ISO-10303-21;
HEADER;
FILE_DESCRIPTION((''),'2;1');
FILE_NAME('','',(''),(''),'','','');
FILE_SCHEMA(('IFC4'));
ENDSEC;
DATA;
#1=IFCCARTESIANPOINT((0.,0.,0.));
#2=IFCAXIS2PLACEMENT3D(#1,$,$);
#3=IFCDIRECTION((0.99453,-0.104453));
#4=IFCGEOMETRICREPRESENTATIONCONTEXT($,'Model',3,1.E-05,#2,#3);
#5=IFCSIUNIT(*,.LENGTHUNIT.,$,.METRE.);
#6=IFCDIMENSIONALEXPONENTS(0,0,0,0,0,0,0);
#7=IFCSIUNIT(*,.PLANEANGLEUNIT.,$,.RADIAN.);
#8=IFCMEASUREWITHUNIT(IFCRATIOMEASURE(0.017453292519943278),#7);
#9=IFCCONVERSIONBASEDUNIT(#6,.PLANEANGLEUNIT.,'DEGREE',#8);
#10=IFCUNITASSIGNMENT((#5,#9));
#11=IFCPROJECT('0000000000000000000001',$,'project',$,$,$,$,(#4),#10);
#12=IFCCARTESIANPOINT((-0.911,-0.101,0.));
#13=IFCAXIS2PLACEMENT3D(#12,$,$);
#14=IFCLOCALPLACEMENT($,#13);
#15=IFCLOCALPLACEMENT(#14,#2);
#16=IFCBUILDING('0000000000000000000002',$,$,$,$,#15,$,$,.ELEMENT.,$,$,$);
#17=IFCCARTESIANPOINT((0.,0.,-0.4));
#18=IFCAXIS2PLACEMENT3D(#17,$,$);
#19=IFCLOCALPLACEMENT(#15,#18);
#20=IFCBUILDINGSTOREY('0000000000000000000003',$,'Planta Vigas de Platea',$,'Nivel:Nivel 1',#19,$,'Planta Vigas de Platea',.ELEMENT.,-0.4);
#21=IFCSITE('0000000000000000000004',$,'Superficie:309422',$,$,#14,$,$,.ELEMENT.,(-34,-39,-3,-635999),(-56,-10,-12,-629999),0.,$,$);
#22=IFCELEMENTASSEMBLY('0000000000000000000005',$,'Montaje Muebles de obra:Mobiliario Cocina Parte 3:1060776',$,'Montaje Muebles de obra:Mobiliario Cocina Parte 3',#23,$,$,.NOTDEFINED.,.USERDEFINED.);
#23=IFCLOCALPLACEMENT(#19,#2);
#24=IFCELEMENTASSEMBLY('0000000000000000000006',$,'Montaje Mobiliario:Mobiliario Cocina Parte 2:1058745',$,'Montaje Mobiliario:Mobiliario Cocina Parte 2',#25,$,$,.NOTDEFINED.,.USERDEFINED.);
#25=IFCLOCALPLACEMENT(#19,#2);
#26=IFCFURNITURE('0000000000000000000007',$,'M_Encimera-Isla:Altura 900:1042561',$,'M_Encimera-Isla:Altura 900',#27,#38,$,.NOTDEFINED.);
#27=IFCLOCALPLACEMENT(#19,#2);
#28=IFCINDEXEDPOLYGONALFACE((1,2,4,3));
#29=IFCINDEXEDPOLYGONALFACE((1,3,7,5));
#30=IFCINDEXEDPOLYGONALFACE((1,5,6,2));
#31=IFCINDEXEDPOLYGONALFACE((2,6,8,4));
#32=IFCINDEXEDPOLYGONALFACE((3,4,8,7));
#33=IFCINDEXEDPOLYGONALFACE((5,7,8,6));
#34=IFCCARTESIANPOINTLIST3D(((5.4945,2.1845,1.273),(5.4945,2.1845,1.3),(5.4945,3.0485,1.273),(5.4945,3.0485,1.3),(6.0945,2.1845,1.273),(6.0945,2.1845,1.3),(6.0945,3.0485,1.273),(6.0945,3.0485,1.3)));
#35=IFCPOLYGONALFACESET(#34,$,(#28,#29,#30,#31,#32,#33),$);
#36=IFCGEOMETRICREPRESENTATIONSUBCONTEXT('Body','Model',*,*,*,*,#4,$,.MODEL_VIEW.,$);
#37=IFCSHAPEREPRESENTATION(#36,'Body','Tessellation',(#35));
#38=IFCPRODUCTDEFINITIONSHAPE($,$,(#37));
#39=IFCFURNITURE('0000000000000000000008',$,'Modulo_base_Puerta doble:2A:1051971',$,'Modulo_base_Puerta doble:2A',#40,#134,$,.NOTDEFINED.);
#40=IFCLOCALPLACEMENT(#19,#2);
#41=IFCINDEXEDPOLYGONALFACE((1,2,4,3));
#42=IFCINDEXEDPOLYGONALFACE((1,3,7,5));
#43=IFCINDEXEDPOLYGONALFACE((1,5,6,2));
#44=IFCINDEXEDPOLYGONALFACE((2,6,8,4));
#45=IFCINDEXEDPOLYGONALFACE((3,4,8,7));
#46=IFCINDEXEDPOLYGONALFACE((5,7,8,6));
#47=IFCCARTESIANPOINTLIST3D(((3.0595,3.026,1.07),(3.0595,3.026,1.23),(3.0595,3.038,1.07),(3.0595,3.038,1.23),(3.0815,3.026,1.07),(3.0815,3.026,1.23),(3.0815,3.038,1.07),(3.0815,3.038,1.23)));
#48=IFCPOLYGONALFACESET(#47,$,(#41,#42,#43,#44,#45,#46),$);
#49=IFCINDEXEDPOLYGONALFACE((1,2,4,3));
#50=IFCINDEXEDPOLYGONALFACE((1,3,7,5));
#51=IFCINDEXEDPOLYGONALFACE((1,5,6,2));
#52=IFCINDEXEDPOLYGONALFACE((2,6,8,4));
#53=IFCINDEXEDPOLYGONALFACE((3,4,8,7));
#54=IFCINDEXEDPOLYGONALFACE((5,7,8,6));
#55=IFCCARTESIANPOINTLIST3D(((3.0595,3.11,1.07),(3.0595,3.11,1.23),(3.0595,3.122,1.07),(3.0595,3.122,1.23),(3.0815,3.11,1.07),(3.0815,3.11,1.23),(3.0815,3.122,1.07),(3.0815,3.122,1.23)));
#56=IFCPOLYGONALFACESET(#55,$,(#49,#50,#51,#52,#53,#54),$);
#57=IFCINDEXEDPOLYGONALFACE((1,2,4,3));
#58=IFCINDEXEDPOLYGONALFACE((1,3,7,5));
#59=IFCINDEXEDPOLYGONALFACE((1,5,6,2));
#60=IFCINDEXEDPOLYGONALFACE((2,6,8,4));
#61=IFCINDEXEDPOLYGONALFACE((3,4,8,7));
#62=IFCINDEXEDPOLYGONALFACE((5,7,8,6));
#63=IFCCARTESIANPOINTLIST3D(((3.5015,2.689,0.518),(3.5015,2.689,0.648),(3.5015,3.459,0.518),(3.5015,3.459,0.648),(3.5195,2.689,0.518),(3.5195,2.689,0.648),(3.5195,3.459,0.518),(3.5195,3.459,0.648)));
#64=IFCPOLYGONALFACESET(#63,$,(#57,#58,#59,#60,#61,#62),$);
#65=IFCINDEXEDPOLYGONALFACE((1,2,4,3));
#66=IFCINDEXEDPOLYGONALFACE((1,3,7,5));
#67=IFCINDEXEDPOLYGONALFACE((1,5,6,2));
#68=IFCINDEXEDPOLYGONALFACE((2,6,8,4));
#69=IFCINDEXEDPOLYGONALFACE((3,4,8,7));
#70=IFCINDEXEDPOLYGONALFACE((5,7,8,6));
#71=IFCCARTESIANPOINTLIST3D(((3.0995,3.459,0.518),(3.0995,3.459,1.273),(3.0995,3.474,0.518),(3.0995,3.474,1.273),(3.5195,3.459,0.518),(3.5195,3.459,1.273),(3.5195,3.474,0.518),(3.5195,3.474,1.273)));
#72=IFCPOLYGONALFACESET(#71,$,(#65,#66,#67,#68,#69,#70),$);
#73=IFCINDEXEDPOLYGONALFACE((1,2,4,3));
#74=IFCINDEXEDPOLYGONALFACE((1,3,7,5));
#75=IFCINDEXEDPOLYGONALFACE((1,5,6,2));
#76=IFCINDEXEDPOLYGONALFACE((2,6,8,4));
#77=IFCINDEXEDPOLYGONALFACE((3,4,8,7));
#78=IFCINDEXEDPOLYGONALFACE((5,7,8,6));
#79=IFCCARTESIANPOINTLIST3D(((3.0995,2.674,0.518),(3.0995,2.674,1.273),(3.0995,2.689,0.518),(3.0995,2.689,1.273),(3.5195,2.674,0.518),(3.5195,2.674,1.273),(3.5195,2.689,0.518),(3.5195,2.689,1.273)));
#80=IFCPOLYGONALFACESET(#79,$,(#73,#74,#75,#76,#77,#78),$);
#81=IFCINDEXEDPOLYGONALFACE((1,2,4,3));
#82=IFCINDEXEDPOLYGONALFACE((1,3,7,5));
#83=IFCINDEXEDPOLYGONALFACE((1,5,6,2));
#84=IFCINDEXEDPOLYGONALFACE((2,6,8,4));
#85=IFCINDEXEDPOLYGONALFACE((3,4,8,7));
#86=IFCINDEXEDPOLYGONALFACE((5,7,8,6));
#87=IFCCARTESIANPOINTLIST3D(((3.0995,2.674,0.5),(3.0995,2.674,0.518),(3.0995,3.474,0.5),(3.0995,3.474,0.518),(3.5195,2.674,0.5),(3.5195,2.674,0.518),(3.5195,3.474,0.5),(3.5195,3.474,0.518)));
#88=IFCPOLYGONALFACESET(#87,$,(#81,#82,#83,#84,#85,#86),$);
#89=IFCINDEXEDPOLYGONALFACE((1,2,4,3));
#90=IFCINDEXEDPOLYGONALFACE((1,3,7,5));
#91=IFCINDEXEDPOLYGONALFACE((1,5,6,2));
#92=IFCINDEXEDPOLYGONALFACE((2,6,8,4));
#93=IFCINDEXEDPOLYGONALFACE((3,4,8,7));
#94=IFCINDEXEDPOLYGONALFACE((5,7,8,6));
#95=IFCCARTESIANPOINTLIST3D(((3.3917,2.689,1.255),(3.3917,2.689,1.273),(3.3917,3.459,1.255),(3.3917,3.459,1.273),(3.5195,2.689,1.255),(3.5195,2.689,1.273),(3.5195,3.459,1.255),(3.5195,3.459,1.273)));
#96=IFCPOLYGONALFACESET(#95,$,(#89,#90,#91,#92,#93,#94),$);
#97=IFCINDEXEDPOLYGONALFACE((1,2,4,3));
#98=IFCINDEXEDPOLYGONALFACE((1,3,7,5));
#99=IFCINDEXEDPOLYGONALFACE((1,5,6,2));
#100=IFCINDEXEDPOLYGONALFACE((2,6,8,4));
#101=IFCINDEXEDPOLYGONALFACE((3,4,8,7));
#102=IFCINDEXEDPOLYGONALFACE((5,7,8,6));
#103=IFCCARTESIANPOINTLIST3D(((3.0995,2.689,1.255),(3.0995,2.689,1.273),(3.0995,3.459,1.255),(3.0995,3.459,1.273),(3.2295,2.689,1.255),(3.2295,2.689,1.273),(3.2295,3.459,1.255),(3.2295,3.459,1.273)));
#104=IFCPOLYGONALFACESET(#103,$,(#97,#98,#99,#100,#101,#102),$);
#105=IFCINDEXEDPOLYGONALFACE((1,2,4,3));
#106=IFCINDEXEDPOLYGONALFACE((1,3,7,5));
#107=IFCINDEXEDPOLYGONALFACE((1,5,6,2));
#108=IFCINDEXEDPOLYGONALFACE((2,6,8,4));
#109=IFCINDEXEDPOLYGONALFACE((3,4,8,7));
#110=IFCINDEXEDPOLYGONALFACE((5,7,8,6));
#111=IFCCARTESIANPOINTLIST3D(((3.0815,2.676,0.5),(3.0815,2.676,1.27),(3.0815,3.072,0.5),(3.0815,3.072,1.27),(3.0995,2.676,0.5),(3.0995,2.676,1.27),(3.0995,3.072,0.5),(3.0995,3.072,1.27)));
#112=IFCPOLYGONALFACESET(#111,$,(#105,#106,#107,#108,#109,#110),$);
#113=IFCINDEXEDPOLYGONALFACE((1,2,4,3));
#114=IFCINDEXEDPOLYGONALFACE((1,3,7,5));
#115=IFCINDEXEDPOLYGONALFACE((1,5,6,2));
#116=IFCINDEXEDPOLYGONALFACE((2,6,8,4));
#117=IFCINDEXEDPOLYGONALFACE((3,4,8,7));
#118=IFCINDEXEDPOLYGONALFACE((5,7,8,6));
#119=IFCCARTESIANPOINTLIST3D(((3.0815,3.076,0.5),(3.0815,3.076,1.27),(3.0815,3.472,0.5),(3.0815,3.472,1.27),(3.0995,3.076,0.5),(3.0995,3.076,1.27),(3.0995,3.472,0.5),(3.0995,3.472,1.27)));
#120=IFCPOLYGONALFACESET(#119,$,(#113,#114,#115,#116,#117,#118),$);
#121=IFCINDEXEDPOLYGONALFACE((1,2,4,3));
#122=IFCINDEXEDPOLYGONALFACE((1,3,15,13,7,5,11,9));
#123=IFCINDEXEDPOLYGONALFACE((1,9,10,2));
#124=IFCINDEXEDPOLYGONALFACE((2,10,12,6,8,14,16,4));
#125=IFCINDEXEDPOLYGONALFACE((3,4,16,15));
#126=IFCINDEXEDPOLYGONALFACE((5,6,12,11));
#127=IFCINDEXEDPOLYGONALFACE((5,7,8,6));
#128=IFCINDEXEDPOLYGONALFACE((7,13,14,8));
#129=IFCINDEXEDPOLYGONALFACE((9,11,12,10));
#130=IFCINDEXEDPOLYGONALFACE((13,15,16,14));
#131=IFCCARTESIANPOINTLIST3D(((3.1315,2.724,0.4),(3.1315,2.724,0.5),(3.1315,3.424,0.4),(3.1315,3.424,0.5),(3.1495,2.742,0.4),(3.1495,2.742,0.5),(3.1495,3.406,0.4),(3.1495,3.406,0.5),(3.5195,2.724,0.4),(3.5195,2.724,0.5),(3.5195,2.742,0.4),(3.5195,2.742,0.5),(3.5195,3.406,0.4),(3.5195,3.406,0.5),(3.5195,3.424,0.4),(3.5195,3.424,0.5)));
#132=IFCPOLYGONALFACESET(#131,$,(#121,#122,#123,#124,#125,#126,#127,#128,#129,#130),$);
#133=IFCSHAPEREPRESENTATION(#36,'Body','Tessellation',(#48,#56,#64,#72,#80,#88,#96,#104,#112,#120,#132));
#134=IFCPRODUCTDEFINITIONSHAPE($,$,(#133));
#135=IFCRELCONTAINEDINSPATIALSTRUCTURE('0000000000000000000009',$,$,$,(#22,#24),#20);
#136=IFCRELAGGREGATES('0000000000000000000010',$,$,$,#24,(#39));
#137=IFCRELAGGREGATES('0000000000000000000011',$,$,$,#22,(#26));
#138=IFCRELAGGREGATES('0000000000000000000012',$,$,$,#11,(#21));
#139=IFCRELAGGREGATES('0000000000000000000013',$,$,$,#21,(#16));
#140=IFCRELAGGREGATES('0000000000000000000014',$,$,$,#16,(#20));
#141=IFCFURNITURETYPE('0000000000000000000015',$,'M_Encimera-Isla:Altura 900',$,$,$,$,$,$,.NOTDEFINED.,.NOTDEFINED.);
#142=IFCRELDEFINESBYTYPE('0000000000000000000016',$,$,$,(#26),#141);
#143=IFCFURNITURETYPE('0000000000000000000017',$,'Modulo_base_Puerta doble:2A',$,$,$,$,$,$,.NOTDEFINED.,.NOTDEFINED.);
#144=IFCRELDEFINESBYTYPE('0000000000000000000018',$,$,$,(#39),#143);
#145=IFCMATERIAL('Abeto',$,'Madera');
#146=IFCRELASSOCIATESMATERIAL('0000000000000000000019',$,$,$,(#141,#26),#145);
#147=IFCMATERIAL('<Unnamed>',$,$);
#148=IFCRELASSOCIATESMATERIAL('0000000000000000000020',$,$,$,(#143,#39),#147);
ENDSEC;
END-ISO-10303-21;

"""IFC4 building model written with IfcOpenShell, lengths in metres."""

from ifc_helpers import new_model, entity, si_unit, converted_unit, direction, frame, frame_2d, origin, origin_2d_with_axis, place, context, subcontext, project, spatial, polyline, rectangle, outline, extrude, source, transform, mapped, material, type_object, type_shapes, element, aggregate, save


model = new_model("IFC4")

# Units and contexts
model_context = context("Model", 3, precision=1e-05, world=origin(), true_north=direction((0.99453, -0.104453)))
body_context = subcontext(model_context, "Body", "Model", "MODEL_VIEW")
ifc_project = project(units=[si_unit("LENGTHUNIT", "METRE"), converted_unit("PLANEANGLEUNIT", "DEGREE", entity("IfcRatioMeasure", 0.017453292519943278), si_unit("PLANEANGLEUNIT", "RADIAN"), dimensions=[0, 0, 0, 0, 0, 0, 0])], contexts=[model_context])

# Site, building, storey
site_placement = place(None, frame((-0.911, -0.101, 0.0)))
site = spatial("IfcSite", under=ifc_project, at=site_placement, Name="Superficie:309422", CompositionType="ELEMENT", RefLatitude=(-34, -39, -3, -635999), RefLongitude=(-56, -10, -12, -629999), RefElevation=0.0)
building_placement = place(site_placement, origin())
building = spatial("IfcBuilding", under=site, at=building_placement, CompositionType="ELEMENT")
storey_placement = place(building_placement, frame((0.0, 0.0, -0.4)))
storey = spatial("IfcBuildingStorey", under=building, at=storey_placement, Name="Planta Vigas de Platea", ObjectType="Nivel:Nivel 1", LongName="Planta Vigas de Platea", CompositionType="ELEMENT", Elevation=-0.4)

# Element assemblies
ifc_material_1 = material(Name="Abeto", Category="Madera")
ifc_material_2 = material(Name="<Unnamed>")
assembly_1_placement = place(storey_placement, origin())
assembly_1 = element("IfcElementAssembly", 1, at=assembly_1_placement, inside=storey, Name="Montaje Muebles de obra:Mobiliario Cocina Parte 3:1060776", ObjectType="Montaje Muebles de obra:Mobiliario Cocina Parte 3", AssemblyPlace="NOTDEFINED", PredefinedType="USERDEFINED")
assembly_2_placement = place(storey_placement, origin())
assembly_2 = element("IfcElementAssembly", 2, at=assembly_2_placement, inside=storey, Name="Montaje Mobiliario:Mobiliario Cocina Parte 2:1058745", ObjectType="Montaje Mobiliario:Mobiliario Cocina Parte 2", AssemblyPlace="NOTDEFINED", PredefinedType="USERDEFINED")

# Furniture
furniture_type_1 = type_object("IfcFurnitureType", Name="M_Encimera-Isla:Altura 900", AssemblyPlace="NOTDEFINED", PredefinedType="NOTDEFINED", material=ifc_material_1)
shared_shape_1 = source(origin(), body_context, "Body", "SweptSolid", [
    extrude(rectangle(XDim=0.864, YDim=0.6, at=frame_2d((0.0, 0.0), x_axis=(1.0, 0.0))), frame((0.432, 0.3, 0.0), z_axis=(0.0, 0.0, 1.0), x_axis=(-1.0, 0.0, 0.0)), (0.0, 0.0, 1.0), 0.027),
])
type_shapes(furniture_type_1, [shared_shape_1])
furniture_1_placement = place(assembly_1_placement, frame((5.4945, 3.0485, 1.273), z_axis=(0.0, 0.0, 1.0), x_axis=(0.0, -1.0, 0.0)))
furniture_1 = element("IfcFurniture", 3, at=furniture_1_placement, type_object=furniture_type_1, material=ifc_material_1, Name="M_Encimera-Isla:Altura 900:1042561", ObjectType="M_Encimera-Isla:Altura 900", PredefinedType="NOTDEFINED", context=body_context, shape_type="MappedRepresentation", body=[
    mapped(shared_shape_1, transform((0.0, 0.0, 0.0), scale=1.0)),
])
furniture_type_2 = type_object("IfcFurnitureType", Name="Modulo_base_Puerta doble:2A", AssemblyPlace="NOTDEFINED", PredefinedType="NOTDEFINED", material=ifc_material_2)
shared_shape_2 = source(origin(), body_context, "Body", "SweptSolid", [
    extrude(rectangle(XDim=0.022, YDim=0.012, at=frame_2d((0.0, 0.0), x_axis=(1.0, 0.0))), frame((0.011, 0.358, 0.67)), (0.0, 0.0, 1.0), 0.16),
    extrude(rectangle(XDim=0.022, YDim=0.012, at=frame_2d((0.0, 0.0), x_axis=(1.0, 0.0))), frame((0.011, 0.442, 0.67)), (0.0, 0.0, 1.0), 0.16),
    extrude(rectangle(XDim=0.77, YDim=0.018, at=frame_2d((0.0, 0.0), x_axis=(1.0, 0.0))), frame((0.451, 0.4, 0.118), z_axis=(0.0, 0.0, 1.0), x_axis=(0.0, 1.0, 0.0)), (0.0, 0.0, 1.0), 0.13),
    extrude(rectangle(XDim=0.015, YDim=0.42, at=frame_2d((0.0, 0.0), x_axis=(1.0, 0.0))), frame((0.25, 0.7925, 0.118), z_axis=(0.0, 0.0, 1.0), x_axis=(0.0, 1.0, 0.0)), (0.0, 0.0, 1.0), 0.755),
    extrude(rectangle(XDim=0.015, YDim=0.42, at=origin_2d_with_axis()), frame((0.25, 0.0075, 0.118), z_axis=(0.0, 0.0, 1.0), x_axis=(0.0, -1.0, 0.0)), (0.0, 0.0, 1.0), 0.755),
    extrude(rectangle(XDim=0.8, YDim=0.42, at=frame_2d((0.0, 0.0), x_axis=(1.0, 0.0))), frame((0.25, 0.4, 0.1), z_axis=(0.0, 0.0, 1.0), x_axis=(0.0, 1.0, 0.0)), (0.0, 0.0, 1.0), 0.018),
    extrude(rectangle(XDim=0.77, YDim=0.1278, at=frame_2d((0.0, 0.0), x_axis=(1.0, 0.0))), frame((0.3961, 0.4, 0.855), z_axis=(0.0, 0.0, 1.0), x_axis=(0.0, 1.0, 0.0)), (0.0, 0.0, 1.0), 0.018),
    extrude(rectangle(XDim=0.77, YDim=0.13, at=frame_2d((0.0, 0.0), x_axis=(1.0, 0.0))), frame((0.105, 0.4, 0.855), z_axis=(0.0, 0.0, 1.0), x_axis=(0.0, 1.0, 0.0)), (0.0, 0.0, 1.0), 0.018),
    extrude(rectangle(XDim=0.018, YDim=0.396, at=frame_2d((0.0, 0.0), x_axis=(1.0, 0.0))), frame((0.031, 0.2, 0.1)), (0.0, 0.0, 1.0), 0.77),
    extrude(rectangle(XDim=0.018, YDim=0.396, at=frame_2d((0.0, 0.0), x_axis=(1.0, 0.0))), frame((0.031, 0.6, 0.1)), (0.0, 0.0, 1.0), 0.77),
    extrude(outline(polyline([(-0.1985, -0.35), (0.1895, -0.35), (0.1895, -0.332), (-0.1805, -0.332), (-0.1805, 0.332), (0.1895, 0.332), (0.1895, 0.35), (-0.1985, 0.35), (-0.1985, -0.35)])), frame((0.2705, 0.4, 0.0)), (0.0, 0.0, 1.0), 0.1),
])
type_shapes(furniture_type_2, [shared_shape_2])
furniture_2_placement = place(assembly_2_placement, frame((3.0595, 2.674, 0.4)))
furniture_2 = element("IfcFurniture", 4, at=furniture_2_placement, type_object=furniture_type_2, material=ifc_material_2, Name="Modulo_base_Puerta doble:2A:1051971", ObjectType="Modulo_base_Puerta doble:2A", PredefinedType="NOTDEFINED", context=body_context, shape_type="MappedRepresentation", body=[
    mapped(shared_shape_2, transform((0.0, 0.0, 0.0), scale=1.0)),
])
aggregate(assembly_2, [furniture_2])
aggregate(assembly_1, [furniture_1])

save(model, "model.ifc")
